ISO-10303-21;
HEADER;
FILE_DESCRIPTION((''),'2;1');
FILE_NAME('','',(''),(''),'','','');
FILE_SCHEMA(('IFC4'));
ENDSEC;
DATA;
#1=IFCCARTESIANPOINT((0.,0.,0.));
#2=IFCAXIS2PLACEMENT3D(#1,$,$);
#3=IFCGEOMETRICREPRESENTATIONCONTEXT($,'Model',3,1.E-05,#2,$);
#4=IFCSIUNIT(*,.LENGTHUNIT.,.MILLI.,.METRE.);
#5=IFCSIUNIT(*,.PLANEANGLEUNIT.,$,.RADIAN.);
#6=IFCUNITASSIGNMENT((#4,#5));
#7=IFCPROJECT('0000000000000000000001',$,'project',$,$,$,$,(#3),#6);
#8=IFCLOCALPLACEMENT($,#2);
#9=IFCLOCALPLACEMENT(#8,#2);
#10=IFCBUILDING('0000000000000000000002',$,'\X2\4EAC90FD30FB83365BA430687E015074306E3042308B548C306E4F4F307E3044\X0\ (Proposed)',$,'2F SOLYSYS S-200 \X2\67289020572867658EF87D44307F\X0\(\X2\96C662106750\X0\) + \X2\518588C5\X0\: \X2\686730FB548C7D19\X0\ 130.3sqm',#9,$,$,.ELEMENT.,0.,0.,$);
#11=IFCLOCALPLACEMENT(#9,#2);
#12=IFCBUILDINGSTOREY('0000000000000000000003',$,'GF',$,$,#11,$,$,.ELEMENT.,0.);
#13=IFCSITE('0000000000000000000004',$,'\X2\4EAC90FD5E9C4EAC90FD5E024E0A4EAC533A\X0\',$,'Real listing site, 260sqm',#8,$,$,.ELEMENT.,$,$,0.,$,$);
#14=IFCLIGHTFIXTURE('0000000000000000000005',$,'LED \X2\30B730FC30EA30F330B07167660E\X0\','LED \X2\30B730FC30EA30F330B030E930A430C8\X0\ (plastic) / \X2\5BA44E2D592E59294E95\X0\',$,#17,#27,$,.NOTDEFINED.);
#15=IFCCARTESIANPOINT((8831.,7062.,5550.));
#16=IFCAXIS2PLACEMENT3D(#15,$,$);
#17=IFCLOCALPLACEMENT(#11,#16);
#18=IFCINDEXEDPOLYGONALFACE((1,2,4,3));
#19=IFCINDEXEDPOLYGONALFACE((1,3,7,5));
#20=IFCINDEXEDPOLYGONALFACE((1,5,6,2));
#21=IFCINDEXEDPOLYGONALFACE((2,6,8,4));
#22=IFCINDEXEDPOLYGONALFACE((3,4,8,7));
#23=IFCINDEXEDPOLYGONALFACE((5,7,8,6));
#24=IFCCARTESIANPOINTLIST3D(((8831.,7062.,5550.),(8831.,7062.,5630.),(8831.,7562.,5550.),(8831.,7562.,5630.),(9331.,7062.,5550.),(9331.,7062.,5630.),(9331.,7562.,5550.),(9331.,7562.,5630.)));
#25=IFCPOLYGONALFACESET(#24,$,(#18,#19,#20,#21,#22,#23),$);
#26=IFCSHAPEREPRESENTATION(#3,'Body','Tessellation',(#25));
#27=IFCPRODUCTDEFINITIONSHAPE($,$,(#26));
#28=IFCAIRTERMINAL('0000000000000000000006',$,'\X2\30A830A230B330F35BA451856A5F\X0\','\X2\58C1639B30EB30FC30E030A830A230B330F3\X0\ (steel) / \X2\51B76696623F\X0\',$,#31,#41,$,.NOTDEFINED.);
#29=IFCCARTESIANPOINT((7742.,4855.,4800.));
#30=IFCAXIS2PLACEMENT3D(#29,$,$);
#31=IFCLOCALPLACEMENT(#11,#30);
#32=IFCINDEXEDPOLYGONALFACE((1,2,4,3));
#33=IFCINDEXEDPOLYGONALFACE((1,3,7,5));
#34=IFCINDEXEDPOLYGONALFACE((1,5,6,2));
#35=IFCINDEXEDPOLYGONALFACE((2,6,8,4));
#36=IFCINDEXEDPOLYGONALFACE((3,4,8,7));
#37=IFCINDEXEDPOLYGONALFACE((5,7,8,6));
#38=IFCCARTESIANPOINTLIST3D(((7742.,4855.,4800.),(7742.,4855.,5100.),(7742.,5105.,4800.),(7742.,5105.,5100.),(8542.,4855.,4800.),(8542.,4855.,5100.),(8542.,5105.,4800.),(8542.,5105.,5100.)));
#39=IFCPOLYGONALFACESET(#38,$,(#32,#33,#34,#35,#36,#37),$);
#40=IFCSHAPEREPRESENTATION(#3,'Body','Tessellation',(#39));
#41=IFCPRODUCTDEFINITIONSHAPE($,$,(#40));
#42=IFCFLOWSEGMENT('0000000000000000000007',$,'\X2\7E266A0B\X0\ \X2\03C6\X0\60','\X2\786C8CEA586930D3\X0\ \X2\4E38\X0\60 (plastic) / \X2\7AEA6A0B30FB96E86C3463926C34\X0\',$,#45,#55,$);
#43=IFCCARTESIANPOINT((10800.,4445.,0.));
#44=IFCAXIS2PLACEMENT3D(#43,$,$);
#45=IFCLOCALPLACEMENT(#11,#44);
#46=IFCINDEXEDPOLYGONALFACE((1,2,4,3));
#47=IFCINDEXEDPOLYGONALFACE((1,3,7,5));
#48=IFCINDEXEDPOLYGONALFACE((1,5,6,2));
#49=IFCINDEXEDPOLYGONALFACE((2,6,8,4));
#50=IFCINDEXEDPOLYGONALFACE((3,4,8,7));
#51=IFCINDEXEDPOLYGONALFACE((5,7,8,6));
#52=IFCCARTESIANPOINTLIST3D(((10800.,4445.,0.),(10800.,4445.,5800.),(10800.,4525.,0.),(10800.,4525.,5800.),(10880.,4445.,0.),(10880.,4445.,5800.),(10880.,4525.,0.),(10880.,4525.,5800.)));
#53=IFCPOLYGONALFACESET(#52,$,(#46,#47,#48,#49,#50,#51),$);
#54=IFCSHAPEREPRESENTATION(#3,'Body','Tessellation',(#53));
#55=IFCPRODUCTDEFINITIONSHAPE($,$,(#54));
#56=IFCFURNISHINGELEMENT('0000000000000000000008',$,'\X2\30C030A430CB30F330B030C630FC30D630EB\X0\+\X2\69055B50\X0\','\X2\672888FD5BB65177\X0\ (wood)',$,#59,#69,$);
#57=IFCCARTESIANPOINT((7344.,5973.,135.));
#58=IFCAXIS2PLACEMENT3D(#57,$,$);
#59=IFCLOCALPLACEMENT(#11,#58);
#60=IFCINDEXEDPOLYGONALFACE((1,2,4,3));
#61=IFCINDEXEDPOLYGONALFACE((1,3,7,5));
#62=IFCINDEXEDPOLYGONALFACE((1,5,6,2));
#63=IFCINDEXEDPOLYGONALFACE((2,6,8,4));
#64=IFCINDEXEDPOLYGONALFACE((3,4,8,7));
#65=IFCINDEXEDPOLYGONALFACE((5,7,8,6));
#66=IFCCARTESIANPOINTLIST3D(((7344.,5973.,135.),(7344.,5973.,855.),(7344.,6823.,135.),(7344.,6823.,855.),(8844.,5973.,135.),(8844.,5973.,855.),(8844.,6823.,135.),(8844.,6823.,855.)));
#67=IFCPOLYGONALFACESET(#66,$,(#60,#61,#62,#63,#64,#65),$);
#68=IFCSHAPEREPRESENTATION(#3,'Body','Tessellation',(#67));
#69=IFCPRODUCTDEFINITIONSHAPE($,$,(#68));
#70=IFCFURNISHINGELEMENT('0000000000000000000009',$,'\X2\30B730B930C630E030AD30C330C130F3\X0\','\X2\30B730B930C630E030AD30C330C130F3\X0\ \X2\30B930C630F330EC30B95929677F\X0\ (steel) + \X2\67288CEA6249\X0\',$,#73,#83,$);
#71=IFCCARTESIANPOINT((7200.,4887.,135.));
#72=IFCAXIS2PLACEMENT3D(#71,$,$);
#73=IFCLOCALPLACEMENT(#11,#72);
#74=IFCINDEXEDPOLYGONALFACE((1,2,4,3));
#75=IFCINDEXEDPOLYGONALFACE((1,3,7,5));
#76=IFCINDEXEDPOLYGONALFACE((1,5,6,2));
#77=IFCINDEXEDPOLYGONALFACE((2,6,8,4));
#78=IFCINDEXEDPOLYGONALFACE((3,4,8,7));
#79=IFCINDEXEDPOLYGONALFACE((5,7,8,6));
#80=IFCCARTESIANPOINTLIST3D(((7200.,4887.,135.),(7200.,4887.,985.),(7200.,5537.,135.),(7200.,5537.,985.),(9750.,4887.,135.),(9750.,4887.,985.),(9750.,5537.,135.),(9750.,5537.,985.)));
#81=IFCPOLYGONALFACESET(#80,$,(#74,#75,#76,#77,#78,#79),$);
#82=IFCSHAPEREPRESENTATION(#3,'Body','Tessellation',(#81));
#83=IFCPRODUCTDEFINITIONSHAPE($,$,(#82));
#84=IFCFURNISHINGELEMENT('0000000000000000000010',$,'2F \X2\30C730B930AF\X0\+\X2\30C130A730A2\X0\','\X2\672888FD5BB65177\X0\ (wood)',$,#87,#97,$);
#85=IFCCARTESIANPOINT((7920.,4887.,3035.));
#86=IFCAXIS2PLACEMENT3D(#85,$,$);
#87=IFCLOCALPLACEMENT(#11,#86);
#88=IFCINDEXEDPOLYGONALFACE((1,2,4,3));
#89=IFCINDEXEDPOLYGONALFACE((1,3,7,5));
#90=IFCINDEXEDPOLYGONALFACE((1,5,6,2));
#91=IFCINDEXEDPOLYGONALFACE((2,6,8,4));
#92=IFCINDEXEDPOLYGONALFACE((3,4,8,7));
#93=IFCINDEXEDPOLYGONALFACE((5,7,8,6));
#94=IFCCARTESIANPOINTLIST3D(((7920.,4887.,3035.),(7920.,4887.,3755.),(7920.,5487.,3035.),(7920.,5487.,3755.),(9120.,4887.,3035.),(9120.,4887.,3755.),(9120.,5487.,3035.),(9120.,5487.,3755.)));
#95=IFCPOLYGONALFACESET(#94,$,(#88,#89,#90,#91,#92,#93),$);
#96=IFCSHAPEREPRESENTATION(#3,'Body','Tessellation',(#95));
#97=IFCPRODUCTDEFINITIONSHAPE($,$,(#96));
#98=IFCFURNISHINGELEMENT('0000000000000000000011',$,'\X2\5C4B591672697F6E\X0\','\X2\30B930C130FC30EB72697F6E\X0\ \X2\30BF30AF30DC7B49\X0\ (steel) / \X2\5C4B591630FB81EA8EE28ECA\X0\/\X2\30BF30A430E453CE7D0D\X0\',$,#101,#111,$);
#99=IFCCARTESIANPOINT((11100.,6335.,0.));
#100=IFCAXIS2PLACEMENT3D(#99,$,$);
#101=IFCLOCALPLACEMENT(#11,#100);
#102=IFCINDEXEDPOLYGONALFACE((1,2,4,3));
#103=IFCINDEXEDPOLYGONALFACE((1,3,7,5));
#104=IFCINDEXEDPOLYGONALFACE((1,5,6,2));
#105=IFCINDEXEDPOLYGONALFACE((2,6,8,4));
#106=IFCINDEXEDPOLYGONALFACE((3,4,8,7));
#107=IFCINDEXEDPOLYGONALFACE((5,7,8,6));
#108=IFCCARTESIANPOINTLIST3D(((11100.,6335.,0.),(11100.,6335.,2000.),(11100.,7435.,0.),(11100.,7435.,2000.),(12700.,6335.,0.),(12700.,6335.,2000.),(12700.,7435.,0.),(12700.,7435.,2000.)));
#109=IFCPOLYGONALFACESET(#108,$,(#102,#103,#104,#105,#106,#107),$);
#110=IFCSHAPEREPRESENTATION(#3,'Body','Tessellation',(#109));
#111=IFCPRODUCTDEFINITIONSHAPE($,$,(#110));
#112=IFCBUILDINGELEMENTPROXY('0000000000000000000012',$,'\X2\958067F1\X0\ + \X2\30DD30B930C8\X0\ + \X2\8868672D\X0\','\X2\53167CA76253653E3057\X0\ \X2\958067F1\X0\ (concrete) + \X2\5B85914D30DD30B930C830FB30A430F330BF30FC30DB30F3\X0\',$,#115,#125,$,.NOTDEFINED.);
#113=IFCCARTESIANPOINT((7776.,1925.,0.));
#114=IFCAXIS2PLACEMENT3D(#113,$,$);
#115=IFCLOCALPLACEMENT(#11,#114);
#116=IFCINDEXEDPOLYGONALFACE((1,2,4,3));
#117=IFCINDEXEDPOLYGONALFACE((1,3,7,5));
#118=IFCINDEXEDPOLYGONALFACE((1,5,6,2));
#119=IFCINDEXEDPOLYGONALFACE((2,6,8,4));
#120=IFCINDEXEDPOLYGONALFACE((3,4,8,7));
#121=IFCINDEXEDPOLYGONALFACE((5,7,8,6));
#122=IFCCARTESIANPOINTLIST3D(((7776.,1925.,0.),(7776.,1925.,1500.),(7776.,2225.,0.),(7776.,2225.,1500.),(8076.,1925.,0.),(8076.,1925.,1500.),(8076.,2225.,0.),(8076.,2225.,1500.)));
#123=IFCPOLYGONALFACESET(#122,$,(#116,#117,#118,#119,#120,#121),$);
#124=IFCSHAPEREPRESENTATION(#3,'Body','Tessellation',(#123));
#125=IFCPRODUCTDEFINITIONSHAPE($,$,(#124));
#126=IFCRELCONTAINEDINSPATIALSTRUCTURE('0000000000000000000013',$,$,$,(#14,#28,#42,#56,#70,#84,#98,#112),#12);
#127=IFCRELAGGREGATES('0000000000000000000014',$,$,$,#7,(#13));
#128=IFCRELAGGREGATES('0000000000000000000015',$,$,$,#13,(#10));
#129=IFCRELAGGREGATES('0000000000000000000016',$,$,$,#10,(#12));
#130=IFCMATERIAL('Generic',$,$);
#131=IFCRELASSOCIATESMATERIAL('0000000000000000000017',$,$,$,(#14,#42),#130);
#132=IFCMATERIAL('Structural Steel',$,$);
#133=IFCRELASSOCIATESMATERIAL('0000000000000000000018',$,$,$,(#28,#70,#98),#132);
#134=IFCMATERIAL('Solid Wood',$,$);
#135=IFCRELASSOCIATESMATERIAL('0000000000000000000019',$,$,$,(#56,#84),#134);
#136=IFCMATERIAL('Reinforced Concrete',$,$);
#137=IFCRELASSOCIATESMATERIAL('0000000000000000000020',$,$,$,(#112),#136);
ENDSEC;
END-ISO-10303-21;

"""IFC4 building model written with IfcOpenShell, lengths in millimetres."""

from ifc_helpers import new_model, si_unit, frame, frame_2d, origin, place, context, project, spatial, rectangle, extrude, material, element, save


model = new_model("IFC4")

# Units and contexts
model_context = context("Model", 3, precision=1e-05, world=origin())
ifc_project = project(units=[si_unit("LENGTHUNIT", "METRE", prefix="MILLI"), si_unit("PLANEANGLEUNIT", "RADIAN")], contexts=[model_context])

# Site, building, storey
site_placement = place(None, origin())
site = spatial("IfcSite", under=ifc_project, at=site_placement, Name="京都府京都市上京区", ObjectType="Real listing site, 260sqm", CompositionType="ELEMENT", RefElevation=0.0)
building_placement = place(site_placement, origin())
building = spatial("IfcBuilding", under=site, at=building_placement, Name="京都・茶室と縁側のある和の住まい (Proposed)", ObjectType="2F SOLYSYS S-200 木造在来軸組み(集成材) + 内装: 桧・和紙 130.3sqm", CompositionType="ELEMENT", ElevationOfRefHeight=0.0, ElevationOfTerrain=0.0)
storey_placement = place(building_placement, origin())
storey = spatial("IfcBuildingStorey", under=building, at=storey_placement, Name="GF", CompositionType="ELEMENT", Elevation=0.0)

# Shared definitions
ifc_material_1 = material(Name="Solid Wood")

# Shared definitions
ifc_material_2 = material(Name="Reinforced Concrete")

# Shared definitions
ifc_material_3 = material(Name="Structural Steel")

# Shared definitions
ifc_material_4 = material(Name="Generic")

# Light fixture
light_fixture_1_placement = place(storey_placement, frame((8831.0, 7062.0, 5550.0)))
element("IfcLightFixture", 1, at=light_fixture_1_placement, inside=storey, material=ifc_material_4, Name="LED シーリング照明", Description="LED シーリングライト (plastic) / 室中央天井", PredefinedType="NOTDEFINED", context=model_context, shape_type="SweptSolid", body=[
    extrude(rectangle(XDim=500.0, YDim=500.0, at=frame_2d((250.0, 250.0))), frame((8831.0, 7062.0, 5550.0)), (0.0, 0.0, 1.0), 80.0),
])

# Air terminal
air_terminal_placement = place(storey_placement, frame((7742.0, 4855.0, 4800.0)))
element("IfcAirTerminal", 2, at=air_terminal_placement, inside=storey, material=ifc_material_3, Name="エアコン室内機", Description="壁掛ルームエアコン (steel) / 冷暖房", PredefinedType="NOTDEFINED", context=model_context, shape_type="SweptSolid", body=[
    extrude(rectangle(XDim=800.0, YDim=250.0, at=frame_2d((400.0, 125.0))), frame((7742.0, 4855.0, 4800.0)), (0.0, 0.0, 1.0), 300.0),
])

# Flow segment
flow_segment_placement = place(storey_placement, frame((10800.0, 4445.0, 0.0)))
element("IfcFlowSegment", 3, at=flow_segment_placement, inside=storey, material=ifc_material_4, Name="縦樋 φ60", Description="硬質塩ビ 丸60 (plastic) / 竪樋・雨水排水", context=model_context, shape_type="SweptSolid", body=[
    extrude(rectangle(XDim=80.0, YDim=80.0, at=frame_2d((40.0, 40.0))), frame((10800.0, 4445.0, 0.0)), (0.0, 0.0, 1.0), 5800.0),
])

# Furnishing elements
furnishing_1_placement = place(storey_placement, frame((7344.0, 5973.0, 135.0)))
element("IfcFurnishingElement", 4, at=furnishing_1_placement, inside=storey, material=ifc_material_1, Name="ダイニングテーブル+椅子", Description="木製家具 (wood)", context=model_context, shape_type="SweptSolid", body=[
    extrude(rectangle(XDim=1500.0, YDim=850.0, at=frame_2d((750.0, 425.0))), frame((7344.0, 5973.0, 135.0)), (0.0, 0.0, 1.0), 720.0),
])
furnishing_2_placement = place(storey_placement, frame((7200.0, 4887.0, 135.0)))
element("IfcFurnishingElement", 5, at=furnishing_2_placement, inside=storey, material=ifc_material_3, Name="システムキッチン", Description="システムキッチン ステンレス天板 (steel) + 木質扉", context=model_context, shape_type="SweptSolid", body=[
    extrude(rectangle(XDim=2550.0, YDim=650.0, at=frame_2d((1275.0, 325.0))), frame((7200.0, 4887.0, 135.0)), (0.0, 0.0, 1.0), 850.0),
])
furnishing_3_placement = place(storey_placement, frame((7920.0, 4887.0, 3035.0)))
element("IfcFurnishingElement", 6, at=furnishing_3_placement, inside=storey, material=ifc_material_1, Name="2F デスク+チェア", Description="木製家具 (wood)", context=model_context, shape_type="SweptSolid", body=[
    extrude(rectangle(XDim=1200.0, YDim=600.0, at=frame_2d((600.0, 300.0))), frame((7920.0, 4887.0, 3035.0)), (0.0, 0.0, 1.0), 720.0),
])
furnishing_4_placement = place(storey_placement, frame((11100.0, 6335.0, 0.0)))
element("IfcFurnishingElement", 7, at=furnishing_4_placement, inside=storey, material=ifc_material_3, Name="屋外物置", Description="スチール物置 タクボ等 (steel) / 屋外・自転車/タイヤ収納", context=model_context, shape_type="SweptSolid", body=[
    extrude(rectangle(XDim=1600.0, YDim=1100.0, at=frame_2d((800.0, 550.0))), frame((11100.0, 6335.0, 0.0)), (0.0, 0.0, 1.0), 2000.0),
])

# Building element proxy
proxy_placement = place(storey_placement, frame((7776.0, 1925.0, 0.0)))
element("IfcBuildingElementProxy", 8, at=proxy_placement, inside=storey, material=ifc_material_2, Name="門柱 + ポスト + 表札", Description="化粧打放し 門柱 (concrete) + 宅配ポスト・インターホン", PredefinedType="NOTDEFINED", context=model_context, shape_type="SweptSolid", body=[
    extrude(rectangle(XDim=300.0, YDim=300.0, at=frame_2d((150.0, 150.0))), frame((7776.0, 1925.0, 0.0)), (0.0, 0.0, 1.0), 1500.0),
])

save(model, "model.ifc")
